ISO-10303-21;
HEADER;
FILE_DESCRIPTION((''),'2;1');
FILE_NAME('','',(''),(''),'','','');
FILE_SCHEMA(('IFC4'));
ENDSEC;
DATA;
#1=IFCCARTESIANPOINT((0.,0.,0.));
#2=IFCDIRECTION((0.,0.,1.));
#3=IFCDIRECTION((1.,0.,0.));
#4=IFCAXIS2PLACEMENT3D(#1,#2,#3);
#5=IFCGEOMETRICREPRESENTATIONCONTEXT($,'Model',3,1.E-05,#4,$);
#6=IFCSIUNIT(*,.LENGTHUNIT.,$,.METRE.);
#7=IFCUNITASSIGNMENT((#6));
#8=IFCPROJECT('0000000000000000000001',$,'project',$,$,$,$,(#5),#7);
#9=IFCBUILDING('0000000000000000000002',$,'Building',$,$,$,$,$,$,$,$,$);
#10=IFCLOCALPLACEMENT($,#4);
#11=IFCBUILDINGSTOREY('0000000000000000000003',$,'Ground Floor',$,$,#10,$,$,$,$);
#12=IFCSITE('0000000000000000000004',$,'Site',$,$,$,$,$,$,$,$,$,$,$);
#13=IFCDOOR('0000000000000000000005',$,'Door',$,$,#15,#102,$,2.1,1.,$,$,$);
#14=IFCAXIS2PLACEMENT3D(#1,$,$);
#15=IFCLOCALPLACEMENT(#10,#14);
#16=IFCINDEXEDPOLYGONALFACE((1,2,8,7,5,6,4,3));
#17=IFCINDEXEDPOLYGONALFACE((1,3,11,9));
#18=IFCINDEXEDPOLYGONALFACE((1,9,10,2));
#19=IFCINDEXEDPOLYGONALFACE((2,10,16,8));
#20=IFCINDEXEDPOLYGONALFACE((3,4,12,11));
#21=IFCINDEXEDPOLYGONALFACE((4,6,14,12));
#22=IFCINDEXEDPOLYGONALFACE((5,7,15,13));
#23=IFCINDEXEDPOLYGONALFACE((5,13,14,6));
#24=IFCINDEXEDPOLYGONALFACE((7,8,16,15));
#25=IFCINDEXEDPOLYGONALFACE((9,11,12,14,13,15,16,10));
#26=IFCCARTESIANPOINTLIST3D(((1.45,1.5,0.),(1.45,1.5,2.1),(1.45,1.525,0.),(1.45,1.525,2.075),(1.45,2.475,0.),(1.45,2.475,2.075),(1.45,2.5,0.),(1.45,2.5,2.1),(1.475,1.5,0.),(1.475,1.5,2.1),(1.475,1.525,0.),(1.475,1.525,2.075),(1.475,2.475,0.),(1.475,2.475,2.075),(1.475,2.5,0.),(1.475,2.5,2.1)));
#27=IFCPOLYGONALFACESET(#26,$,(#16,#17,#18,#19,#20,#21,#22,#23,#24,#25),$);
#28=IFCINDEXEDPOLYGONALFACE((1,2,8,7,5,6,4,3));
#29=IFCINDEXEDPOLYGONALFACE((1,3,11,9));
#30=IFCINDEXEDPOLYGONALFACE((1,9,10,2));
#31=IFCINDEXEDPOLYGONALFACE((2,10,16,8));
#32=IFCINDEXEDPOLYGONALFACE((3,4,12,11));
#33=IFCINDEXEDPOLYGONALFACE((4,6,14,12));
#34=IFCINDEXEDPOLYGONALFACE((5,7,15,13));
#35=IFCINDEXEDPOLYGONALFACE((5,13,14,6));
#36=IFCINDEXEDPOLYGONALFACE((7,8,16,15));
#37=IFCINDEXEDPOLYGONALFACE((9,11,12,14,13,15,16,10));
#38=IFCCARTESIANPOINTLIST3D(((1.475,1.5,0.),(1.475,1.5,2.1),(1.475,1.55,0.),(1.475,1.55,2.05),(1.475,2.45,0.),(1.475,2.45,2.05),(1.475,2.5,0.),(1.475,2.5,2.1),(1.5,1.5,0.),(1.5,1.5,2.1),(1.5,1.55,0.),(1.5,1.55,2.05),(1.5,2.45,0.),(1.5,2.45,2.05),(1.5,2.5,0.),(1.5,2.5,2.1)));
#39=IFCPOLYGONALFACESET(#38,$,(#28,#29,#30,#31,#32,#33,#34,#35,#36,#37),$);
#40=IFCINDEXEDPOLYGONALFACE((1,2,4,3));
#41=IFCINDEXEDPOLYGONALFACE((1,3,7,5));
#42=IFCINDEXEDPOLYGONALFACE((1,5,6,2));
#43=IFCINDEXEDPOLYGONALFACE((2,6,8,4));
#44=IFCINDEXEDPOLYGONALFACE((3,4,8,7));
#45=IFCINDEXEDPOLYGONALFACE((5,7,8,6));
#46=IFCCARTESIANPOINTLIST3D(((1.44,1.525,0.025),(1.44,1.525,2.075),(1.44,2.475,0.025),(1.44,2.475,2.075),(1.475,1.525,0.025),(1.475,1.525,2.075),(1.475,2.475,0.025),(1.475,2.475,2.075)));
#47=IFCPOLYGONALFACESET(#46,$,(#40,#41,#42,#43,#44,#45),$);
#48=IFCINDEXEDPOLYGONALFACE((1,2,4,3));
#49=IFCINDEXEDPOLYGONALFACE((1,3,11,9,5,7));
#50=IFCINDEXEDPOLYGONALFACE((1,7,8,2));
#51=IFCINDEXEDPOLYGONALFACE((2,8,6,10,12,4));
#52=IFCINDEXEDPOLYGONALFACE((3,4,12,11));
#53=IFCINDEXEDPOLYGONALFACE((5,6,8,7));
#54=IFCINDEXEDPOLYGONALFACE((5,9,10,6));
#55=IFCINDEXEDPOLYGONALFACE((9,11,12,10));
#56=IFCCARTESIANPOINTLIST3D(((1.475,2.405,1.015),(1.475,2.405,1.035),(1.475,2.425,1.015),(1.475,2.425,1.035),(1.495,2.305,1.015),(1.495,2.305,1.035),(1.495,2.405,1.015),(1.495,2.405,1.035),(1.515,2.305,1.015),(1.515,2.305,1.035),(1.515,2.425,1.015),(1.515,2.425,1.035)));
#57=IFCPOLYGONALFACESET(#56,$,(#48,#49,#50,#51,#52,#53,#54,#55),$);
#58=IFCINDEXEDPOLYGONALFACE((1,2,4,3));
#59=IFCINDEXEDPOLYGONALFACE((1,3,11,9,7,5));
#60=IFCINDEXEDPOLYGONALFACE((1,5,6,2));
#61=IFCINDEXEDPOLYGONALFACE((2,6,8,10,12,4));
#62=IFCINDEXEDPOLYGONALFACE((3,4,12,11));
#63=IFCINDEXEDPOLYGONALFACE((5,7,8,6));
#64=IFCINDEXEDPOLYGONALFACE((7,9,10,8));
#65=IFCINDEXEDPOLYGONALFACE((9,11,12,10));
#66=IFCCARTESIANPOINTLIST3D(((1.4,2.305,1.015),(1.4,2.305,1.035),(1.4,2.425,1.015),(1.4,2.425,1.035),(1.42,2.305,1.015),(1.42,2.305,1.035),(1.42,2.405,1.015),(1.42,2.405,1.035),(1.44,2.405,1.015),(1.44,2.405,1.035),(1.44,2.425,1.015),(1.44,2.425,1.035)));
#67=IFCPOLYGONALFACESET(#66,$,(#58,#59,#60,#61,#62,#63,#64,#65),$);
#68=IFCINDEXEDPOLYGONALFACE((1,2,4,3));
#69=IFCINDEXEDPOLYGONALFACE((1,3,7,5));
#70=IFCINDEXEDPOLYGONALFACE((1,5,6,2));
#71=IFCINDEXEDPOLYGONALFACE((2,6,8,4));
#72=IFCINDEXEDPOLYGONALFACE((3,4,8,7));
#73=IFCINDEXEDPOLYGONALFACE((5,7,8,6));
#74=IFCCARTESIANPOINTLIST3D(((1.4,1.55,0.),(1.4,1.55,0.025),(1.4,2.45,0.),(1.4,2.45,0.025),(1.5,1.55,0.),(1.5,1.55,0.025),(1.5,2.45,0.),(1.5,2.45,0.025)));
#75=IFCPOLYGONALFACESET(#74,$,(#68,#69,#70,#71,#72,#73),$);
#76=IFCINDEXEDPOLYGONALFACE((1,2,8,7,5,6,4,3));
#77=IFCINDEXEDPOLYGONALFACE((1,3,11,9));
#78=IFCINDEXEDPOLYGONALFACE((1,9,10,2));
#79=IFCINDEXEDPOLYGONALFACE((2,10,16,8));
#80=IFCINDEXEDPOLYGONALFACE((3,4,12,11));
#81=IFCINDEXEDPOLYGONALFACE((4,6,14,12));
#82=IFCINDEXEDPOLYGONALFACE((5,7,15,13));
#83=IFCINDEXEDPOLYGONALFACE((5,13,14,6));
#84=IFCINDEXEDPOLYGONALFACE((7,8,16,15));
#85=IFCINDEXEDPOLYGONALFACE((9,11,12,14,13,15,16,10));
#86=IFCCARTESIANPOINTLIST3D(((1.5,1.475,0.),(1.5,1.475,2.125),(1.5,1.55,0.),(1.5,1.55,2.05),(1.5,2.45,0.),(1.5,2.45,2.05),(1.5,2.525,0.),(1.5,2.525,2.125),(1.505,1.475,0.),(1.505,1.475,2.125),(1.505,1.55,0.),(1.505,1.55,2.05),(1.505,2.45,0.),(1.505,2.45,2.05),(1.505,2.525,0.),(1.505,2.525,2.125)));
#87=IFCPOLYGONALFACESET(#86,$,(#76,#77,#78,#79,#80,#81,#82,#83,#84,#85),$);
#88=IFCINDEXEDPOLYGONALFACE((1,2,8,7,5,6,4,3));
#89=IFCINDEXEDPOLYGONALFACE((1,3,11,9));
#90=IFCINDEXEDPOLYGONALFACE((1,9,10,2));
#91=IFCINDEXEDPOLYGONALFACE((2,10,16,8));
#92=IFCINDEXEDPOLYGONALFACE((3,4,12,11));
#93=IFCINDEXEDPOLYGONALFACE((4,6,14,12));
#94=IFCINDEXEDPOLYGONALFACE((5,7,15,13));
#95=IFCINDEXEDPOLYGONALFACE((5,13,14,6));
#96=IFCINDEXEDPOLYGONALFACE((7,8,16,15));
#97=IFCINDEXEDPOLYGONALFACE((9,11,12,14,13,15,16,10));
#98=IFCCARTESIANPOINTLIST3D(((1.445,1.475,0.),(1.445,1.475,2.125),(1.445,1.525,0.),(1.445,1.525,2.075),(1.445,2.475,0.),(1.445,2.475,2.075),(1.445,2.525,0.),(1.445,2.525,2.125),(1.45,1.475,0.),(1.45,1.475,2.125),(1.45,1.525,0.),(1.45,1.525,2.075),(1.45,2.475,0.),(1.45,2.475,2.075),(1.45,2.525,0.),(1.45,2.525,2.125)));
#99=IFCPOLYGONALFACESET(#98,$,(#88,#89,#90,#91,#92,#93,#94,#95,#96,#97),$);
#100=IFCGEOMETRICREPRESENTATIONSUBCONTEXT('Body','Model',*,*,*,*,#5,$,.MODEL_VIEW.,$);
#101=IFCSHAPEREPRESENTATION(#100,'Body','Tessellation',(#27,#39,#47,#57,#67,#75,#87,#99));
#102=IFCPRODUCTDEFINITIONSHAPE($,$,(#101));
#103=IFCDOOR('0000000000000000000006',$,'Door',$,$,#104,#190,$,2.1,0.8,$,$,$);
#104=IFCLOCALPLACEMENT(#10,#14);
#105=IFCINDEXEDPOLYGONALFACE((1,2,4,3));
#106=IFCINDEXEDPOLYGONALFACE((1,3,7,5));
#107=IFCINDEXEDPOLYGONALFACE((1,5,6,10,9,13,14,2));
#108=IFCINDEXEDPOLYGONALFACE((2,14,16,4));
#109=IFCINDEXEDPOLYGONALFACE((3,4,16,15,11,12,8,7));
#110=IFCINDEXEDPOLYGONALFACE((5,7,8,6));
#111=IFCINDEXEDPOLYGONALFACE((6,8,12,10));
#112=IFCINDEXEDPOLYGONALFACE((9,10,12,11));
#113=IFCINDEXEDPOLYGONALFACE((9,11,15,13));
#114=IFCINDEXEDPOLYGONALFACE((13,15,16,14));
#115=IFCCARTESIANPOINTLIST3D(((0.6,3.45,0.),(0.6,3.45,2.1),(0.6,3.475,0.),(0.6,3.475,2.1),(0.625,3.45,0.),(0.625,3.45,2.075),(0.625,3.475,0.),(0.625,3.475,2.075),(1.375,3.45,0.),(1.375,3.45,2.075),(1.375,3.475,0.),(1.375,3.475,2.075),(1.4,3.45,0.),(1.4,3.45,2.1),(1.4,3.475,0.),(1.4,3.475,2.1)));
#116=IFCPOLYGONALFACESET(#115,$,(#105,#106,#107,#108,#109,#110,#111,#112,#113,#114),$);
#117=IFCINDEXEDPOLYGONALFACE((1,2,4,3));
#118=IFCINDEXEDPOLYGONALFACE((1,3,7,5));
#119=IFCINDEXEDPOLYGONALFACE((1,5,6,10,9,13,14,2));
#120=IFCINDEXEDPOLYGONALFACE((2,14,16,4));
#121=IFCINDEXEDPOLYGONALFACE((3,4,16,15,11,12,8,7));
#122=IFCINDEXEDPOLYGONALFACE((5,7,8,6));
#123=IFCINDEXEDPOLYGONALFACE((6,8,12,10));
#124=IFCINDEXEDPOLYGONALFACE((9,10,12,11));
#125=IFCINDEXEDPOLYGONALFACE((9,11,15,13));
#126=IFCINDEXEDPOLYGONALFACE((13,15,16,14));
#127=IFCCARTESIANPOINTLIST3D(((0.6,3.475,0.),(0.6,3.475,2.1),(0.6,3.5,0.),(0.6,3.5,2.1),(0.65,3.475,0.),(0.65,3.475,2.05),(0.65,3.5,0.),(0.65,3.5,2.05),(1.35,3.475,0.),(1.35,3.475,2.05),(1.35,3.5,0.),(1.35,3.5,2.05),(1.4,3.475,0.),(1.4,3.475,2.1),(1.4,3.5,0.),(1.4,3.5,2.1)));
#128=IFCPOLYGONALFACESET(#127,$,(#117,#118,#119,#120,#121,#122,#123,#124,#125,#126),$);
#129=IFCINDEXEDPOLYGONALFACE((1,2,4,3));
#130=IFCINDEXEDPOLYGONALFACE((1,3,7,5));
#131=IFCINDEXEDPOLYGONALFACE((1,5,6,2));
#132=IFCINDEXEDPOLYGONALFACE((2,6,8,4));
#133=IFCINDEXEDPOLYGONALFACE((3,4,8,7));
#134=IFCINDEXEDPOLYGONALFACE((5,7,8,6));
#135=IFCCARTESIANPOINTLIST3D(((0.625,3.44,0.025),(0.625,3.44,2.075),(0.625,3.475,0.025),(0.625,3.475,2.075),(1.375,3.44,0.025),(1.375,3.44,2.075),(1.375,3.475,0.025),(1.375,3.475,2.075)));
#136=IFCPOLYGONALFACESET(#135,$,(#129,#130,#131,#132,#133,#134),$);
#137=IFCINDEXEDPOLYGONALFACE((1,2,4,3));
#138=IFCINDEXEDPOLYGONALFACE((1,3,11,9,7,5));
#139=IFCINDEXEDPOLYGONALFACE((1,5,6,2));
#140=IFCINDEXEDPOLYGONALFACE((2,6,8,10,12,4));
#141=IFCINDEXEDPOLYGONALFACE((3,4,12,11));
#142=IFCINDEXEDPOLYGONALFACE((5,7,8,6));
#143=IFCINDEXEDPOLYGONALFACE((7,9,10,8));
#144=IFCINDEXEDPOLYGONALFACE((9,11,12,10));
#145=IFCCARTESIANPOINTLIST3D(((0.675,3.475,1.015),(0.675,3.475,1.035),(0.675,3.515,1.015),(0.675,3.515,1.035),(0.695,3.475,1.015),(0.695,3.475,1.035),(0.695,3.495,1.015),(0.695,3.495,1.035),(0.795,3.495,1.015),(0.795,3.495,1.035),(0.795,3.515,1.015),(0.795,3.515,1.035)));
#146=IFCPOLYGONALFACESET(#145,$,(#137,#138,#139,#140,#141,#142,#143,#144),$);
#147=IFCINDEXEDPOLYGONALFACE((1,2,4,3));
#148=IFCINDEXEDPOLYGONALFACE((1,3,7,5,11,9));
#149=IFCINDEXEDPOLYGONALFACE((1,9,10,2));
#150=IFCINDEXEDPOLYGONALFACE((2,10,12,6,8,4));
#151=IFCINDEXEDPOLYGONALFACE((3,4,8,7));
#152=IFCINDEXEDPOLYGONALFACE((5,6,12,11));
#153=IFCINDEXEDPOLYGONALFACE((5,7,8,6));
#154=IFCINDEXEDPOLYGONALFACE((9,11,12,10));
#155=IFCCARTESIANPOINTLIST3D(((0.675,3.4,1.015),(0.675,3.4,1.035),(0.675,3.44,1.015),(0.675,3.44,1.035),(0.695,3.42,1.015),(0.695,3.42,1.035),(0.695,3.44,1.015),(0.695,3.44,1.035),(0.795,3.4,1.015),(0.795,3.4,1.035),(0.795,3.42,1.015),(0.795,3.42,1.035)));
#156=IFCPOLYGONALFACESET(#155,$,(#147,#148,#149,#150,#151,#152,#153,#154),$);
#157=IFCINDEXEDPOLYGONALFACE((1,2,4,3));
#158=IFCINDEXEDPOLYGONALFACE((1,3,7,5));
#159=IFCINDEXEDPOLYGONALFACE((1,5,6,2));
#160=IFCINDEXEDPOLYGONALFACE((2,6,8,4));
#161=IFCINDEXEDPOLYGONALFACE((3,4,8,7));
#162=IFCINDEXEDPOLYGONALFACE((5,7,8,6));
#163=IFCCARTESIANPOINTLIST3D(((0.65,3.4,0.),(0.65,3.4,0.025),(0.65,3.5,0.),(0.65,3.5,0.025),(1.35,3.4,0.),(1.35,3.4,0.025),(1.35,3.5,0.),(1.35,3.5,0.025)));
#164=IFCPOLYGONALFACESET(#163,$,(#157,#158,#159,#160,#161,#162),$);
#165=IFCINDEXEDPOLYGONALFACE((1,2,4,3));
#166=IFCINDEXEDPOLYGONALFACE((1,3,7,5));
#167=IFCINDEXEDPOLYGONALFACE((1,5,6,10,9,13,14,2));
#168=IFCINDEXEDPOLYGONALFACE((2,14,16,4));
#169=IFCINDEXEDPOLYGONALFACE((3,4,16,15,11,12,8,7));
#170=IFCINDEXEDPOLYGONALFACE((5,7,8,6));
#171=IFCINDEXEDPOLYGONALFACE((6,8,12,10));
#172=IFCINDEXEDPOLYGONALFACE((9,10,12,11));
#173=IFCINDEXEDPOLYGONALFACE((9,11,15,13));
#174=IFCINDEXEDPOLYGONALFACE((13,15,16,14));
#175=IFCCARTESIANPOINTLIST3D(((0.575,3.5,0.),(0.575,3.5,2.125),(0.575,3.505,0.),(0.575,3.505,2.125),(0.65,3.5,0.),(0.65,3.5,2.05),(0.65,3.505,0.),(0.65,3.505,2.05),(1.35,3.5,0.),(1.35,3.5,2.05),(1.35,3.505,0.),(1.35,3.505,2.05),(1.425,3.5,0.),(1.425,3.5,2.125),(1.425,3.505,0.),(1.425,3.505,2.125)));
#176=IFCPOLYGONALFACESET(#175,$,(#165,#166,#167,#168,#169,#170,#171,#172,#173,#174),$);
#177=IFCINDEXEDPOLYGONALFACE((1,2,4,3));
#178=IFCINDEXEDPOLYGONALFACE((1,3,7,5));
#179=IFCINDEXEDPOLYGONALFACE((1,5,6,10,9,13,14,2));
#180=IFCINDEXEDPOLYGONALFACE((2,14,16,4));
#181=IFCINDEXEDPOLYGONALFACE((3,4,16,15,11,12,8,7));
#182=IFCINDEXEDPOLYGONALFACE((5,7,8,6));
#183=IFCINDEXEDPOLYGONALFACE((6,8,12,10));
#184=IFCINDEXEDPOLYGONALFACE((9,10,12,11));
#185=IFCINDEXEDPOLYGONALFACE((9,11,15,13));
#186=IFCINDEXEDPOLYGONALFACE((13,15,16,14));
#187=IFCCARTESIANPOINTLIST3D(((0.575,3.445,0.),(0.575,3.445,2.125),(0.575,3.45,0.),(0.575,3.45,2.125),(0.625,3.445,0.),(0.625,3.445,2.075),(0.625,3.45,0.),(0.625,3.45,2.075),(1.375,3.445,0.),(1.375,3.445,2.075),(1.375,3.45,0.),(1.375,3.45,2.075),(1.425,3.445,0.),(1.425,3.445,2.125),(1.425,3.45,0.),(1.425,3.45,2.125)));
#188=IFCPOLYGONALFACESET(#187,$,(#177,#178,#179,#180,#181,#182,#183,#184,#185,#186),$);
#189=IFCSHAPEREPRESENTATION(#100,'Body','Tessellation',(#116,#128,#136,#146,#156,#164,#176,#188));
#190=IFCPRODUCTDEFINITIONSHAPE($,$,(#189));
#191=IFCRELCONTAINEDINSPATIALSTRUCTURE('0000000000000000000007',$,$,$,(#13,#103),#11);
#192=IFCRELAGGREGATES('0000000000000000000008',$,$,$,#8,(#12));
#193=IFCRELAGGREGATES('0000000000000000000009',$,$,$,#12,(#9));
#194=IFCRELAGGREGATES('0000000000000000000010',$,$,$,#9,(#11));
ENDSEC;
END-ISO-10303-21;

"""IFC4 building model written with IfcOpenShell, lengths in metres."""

from ifc_helpers import new_model, si_unit, frame, origin_with_axes, place, context, subcontext, project, spatial, line, indexed_curve, outline, extrude, element, save


model = new_model("IFC4")

# Units and contexts
model_context = context("Model", 3, precision=1e-05, world=origin_with_axes())
body_context = subcontext(model_context, "Body", "Model", "MODEL_VIEW")
ifc_project = project(units=[si_unit("LENGTHUNIT", "METRE")], contexts=[model_context])

# Site, building, storey
site = spatial("IfcSite", under=ifc_project, Name="Site")
building = spatial("IfcBuilding", under=site, Name="Building")
storey_placement = place(None, origin_with_axes())
storey = spatial("IfcBuildingStorey", under=building, at=storey_placement, Name="Ground Floor")

# Doors
door_1_placement = place(storey_placement, frame((1.5, 1.5, 0.0), z_axis=(0.0, 0.0, 1.0), x_axis=(0.0, 1.0, 0.0)))
element("IfcDoor", 1, at=door_1_placement, inside=storey, Name="Door", OverallHeight=2.1, OverallWidth=1.0, context=body_context, shape_type="SweptSolid", body=[
    extrude(outline(indexed_curve([(0.0, 0.0), (0.0, 2.1), (1.0, 2.1), (1.0, 0.0), (0.975, 0.0), (0.975, 2.075), (0.025, 2.075), (0.025, 0.0)], segments=[line(1, 2, 3, 4, 5, 6, 7, 8, 1)])), frame((0.0, 0.025, 0.0), z_axis=(0.0, -1.0, 0.0), x_axis=(1.0, 0.0, 0.0)), (0.0, 0.0, -1.0), 0.025),
    extrude(outline(indexed_curve([(0.0, 0.0), (0.0, 2.1), (1.0, 2.1), (1.0, 0.0), (0.95, 0.0), (0.95, 2.05), (0.05, 2.05), (0.05, 0.0)], segments=[line(1, 2, 3, 4, 5, 6, 7, 8, 1)])), frame((0.0, 0.0, 0.0), z_axis=(0.0, -1.0, 0.0), x_axis=(1.0, 0.0, 0.0)), (0.0, 0.0, -1.0), 0.025),
    extrude(outline(indexed_curve([(0.0, 0.0), (0.95, 0.0), (0.95, 0.035), (0.0, 0.035)], segments=[line(1, 2, 3, 4, 1)])), frame((0.025, 0.025, 0.025), z_axis=(0.0, 0.0, 1.0), x_axis=(1.0, 0.0, 0.0)), (0.0, 0.0, 1.0), 2.05),
    extrude(outline(indexed_curve([(0.0, 0.0), (0.0, -0.04), (-0.12, -0.04), (-0.12, -0.02), (-0.02, -0.02), (-0.02, 0.0)], segments=[line(1, 2, 3, 4, 5, 6, 1)])), frame((0.925, 0.025, 1.015), z_axis=(0.0, 0.0, 1.0), x_axis=(1.0, 0.0, 0.0)), (0.0, 0.0, 1.0), 0.02),
    extrude(outline(indexed_curve([(0.0, 0.0), (0.0, 0.04), (-0.12, 0.04), (-0.12, 0.02), (-0.02, 0.02), (-0.02, 0.0)], segments=[line(1, 2, 3, 4, 5, 6, 1)])), frame((0.925, 0.06, 1.015), z_axis=(0.0, 0.0, 1.0), x_axis=(1.0, 0.0, 0.0)), (0.0, 0.0, 1.0), 0.02),
    extrude(outline(indexed_curve([(0.0, 0.0), (0.9, 0.0), (0.9, 0.1), (0.0, 0.1)], segments=[line(1, 2, 3, 4, 1)])), frame((0.05, 0.0, 0.0), z_axis=(0.0, 0.0, 1.0), x_axis=(1.0, 0.0, 0.0)), (0.0, 0.0, 1.0), 0.025),
    extrude(outline(indexed_curve([(0.0, 0.0), (0.0, 2.125), (1.05, 2.125), (1.05, 0.0), (0.975, 0.0), (0.975, 2.05), (0.075, 2.05), (0.075, 0.0)], segments=[line(1, 2, 3, 4, 5, 6, 7, 8, 1)])), frame((-0.025, -0.005, 0.0), z_axis=(0.0, -1.0, 0.0), x_axis=(1.0, 0.0, 0.0)), (0.0, 0.0, -1.0), 0.005),
    extrude(outline(indexed_curve([(0.0, 0.0), (0.0, 2.125), (1.05, 2.125), (1.05, 0.0), (1.0, 0.0), (1.0, 2.075), (0.05, 2.075), (0.05, 0.0)], segments=[line(1, 2, 3, 4, 5, 6, 7, 8, 1)])), frame((-0.025, 0.05, 0.0), z_axis=(0.0, -1.0, 0.0), x_axis=(1.0, 0.0, 0.0)), (0.0, 0.0, -1.0), 0.005),
])
door_2_placement = place(storey_placement, frame((1.4, 3.5, 0.0), z_axis=(0.0, 0.0, 1.0), x_axis=(-1.0, 0.0, 0.0)))
element("IfcDoor", 2, at=door_2_placement, inside=storey, Name="Door", OverallHeight=2.1, OverallWidth=0.8, context=body_context, shape_type="SweptSolid", body=[
    extrude(outline(indexed_curve([(0.0, 0.0), (0.0, 2.1), (0.8, 2.1), (0.8, 0.0), (0.775, 0.0), (0.775, 2.075), (0.025, 2.075), (0.025, 0.0)], segments=[line(1, 2, 3, 4, 5, 6, 7, 8, 1)])), frame((0.0, 0.025, 0.0), z_axis=(0.0, -1.0, 0.0), x_axis=(1.0, 0.0, 0.0)), (0.0, 0.0, -1.0), 0.025),
    extrude(outline(indexed_curve([(0.0, 0.0), (0.0, 2.1), (0.8, 2.1), (0.8, 0.0), (0.75, 0.0), (0.75, 2.05), (0.05, 2.05), (0.05, 0.0)], segments=[line(1, 2, 3, 4, 5, 6, 7, 8, 1)])), frame((0.0, 0.0, 0.0), z_axis=(0.0, -1.0, 0.0), x_axis=(1.0, 0.0, 0.0)), (0.0, 0.0, -1.0), 0.025),
    extrude(outline(indexed_curve([(0.0, 0.0), (0.75, 0.0), (0.75, 0.035), (0.0, 0.035)], segments=[line(1, 2, 3, 4, 1)])), frame((0.025, 0.025, 0.025), z_axis=(0.0, 0.0, 1.0), x_axis=(1.0, 0.0, 0.0)), (0.0, 0.0, 1.0), 2.05),
    extrude(outline(indexed_curve([(0.0, 0.0), (0.0, -0.04), (-0.12, -0.04), (-0.12, -0.02), (-0.02, -0.02), (-0.02, 0.0)], segments=[line(1, 2, 3, 4, 5, 6, 1)])), frame((0.725, 0.025, 1.015), z_axis=(0.0, 0.0, 1.0), x_axis=(1.0, 0.0, 0.0)), (0.0, 0.0, 1.0), 0.02),
    extrude(outline(indexed_curve([(0.0, 0.0), (0.0, 0.04), (-0.12, 0.04), (-0.12, 0.02), (-0.02, 0.02), (-0.02, 0.0)], segments=[line(1, 2, 3, 4, 5, 6, 1)])), frame((0.725, 0.06, 1.015), z_axis=(0.0, 0.0, 1.0), x_axis=(1.0, 0.0, 0.0)), (0.0, 0.0, 1.0), 0.02),
    extrude(outline(indexed_curve([(0.0, 0.0), (0.7, 0.0), (0.7, 0.1), (0.0, 0.1)], segments=[line(1, 2, 3, 4, 1)])), frame((0.05, 0.0, 0.0), z_axis=(0.0, 0.0, 1.0), x_axis=(1.0, 0.0, 0.0)), (0.0, 0.0, 1.0), 0.025),
    extrude(outline(indexed_curve([(0.0, 0.0), (0.0, 2.125), (0.85, 2.125), (0.85, 0.0), (0.775, 0.0), (0.775, 2.05), (0.075, 2.05), (0.075, 0.0)], segments=[line(1, 2, 3, 4, 5, 6, 7, 8, 1)])), frame((-0.025, -0.005, 0.0), z_axis=(0.0, -1.0, 0.0), x_axis=(1.0, 0.0, 0.0)), (0.0, 0.0, -1.0), 0.005),
    extrude(outline(indexed_curve([(0.0, 0.0), (0.0, 2.125), (0.85, 2.125), (0.85, 0.0), (0.8, 0.0), (0.8, 2.075), (0.05, 2.075), (0.05, 0.0)], segments=[line(1, 2, 3, 4, 5, 6, 7, 8, 1)])), frame((-0.025, 0.05, 0.0), z_axis=(0.0, -1.0, 0.0), x_axis=(1.0, 0.0, 0.0)), (0.0, 0.0, -1.0), 0.005),
])

save(model, "model.ifc")
